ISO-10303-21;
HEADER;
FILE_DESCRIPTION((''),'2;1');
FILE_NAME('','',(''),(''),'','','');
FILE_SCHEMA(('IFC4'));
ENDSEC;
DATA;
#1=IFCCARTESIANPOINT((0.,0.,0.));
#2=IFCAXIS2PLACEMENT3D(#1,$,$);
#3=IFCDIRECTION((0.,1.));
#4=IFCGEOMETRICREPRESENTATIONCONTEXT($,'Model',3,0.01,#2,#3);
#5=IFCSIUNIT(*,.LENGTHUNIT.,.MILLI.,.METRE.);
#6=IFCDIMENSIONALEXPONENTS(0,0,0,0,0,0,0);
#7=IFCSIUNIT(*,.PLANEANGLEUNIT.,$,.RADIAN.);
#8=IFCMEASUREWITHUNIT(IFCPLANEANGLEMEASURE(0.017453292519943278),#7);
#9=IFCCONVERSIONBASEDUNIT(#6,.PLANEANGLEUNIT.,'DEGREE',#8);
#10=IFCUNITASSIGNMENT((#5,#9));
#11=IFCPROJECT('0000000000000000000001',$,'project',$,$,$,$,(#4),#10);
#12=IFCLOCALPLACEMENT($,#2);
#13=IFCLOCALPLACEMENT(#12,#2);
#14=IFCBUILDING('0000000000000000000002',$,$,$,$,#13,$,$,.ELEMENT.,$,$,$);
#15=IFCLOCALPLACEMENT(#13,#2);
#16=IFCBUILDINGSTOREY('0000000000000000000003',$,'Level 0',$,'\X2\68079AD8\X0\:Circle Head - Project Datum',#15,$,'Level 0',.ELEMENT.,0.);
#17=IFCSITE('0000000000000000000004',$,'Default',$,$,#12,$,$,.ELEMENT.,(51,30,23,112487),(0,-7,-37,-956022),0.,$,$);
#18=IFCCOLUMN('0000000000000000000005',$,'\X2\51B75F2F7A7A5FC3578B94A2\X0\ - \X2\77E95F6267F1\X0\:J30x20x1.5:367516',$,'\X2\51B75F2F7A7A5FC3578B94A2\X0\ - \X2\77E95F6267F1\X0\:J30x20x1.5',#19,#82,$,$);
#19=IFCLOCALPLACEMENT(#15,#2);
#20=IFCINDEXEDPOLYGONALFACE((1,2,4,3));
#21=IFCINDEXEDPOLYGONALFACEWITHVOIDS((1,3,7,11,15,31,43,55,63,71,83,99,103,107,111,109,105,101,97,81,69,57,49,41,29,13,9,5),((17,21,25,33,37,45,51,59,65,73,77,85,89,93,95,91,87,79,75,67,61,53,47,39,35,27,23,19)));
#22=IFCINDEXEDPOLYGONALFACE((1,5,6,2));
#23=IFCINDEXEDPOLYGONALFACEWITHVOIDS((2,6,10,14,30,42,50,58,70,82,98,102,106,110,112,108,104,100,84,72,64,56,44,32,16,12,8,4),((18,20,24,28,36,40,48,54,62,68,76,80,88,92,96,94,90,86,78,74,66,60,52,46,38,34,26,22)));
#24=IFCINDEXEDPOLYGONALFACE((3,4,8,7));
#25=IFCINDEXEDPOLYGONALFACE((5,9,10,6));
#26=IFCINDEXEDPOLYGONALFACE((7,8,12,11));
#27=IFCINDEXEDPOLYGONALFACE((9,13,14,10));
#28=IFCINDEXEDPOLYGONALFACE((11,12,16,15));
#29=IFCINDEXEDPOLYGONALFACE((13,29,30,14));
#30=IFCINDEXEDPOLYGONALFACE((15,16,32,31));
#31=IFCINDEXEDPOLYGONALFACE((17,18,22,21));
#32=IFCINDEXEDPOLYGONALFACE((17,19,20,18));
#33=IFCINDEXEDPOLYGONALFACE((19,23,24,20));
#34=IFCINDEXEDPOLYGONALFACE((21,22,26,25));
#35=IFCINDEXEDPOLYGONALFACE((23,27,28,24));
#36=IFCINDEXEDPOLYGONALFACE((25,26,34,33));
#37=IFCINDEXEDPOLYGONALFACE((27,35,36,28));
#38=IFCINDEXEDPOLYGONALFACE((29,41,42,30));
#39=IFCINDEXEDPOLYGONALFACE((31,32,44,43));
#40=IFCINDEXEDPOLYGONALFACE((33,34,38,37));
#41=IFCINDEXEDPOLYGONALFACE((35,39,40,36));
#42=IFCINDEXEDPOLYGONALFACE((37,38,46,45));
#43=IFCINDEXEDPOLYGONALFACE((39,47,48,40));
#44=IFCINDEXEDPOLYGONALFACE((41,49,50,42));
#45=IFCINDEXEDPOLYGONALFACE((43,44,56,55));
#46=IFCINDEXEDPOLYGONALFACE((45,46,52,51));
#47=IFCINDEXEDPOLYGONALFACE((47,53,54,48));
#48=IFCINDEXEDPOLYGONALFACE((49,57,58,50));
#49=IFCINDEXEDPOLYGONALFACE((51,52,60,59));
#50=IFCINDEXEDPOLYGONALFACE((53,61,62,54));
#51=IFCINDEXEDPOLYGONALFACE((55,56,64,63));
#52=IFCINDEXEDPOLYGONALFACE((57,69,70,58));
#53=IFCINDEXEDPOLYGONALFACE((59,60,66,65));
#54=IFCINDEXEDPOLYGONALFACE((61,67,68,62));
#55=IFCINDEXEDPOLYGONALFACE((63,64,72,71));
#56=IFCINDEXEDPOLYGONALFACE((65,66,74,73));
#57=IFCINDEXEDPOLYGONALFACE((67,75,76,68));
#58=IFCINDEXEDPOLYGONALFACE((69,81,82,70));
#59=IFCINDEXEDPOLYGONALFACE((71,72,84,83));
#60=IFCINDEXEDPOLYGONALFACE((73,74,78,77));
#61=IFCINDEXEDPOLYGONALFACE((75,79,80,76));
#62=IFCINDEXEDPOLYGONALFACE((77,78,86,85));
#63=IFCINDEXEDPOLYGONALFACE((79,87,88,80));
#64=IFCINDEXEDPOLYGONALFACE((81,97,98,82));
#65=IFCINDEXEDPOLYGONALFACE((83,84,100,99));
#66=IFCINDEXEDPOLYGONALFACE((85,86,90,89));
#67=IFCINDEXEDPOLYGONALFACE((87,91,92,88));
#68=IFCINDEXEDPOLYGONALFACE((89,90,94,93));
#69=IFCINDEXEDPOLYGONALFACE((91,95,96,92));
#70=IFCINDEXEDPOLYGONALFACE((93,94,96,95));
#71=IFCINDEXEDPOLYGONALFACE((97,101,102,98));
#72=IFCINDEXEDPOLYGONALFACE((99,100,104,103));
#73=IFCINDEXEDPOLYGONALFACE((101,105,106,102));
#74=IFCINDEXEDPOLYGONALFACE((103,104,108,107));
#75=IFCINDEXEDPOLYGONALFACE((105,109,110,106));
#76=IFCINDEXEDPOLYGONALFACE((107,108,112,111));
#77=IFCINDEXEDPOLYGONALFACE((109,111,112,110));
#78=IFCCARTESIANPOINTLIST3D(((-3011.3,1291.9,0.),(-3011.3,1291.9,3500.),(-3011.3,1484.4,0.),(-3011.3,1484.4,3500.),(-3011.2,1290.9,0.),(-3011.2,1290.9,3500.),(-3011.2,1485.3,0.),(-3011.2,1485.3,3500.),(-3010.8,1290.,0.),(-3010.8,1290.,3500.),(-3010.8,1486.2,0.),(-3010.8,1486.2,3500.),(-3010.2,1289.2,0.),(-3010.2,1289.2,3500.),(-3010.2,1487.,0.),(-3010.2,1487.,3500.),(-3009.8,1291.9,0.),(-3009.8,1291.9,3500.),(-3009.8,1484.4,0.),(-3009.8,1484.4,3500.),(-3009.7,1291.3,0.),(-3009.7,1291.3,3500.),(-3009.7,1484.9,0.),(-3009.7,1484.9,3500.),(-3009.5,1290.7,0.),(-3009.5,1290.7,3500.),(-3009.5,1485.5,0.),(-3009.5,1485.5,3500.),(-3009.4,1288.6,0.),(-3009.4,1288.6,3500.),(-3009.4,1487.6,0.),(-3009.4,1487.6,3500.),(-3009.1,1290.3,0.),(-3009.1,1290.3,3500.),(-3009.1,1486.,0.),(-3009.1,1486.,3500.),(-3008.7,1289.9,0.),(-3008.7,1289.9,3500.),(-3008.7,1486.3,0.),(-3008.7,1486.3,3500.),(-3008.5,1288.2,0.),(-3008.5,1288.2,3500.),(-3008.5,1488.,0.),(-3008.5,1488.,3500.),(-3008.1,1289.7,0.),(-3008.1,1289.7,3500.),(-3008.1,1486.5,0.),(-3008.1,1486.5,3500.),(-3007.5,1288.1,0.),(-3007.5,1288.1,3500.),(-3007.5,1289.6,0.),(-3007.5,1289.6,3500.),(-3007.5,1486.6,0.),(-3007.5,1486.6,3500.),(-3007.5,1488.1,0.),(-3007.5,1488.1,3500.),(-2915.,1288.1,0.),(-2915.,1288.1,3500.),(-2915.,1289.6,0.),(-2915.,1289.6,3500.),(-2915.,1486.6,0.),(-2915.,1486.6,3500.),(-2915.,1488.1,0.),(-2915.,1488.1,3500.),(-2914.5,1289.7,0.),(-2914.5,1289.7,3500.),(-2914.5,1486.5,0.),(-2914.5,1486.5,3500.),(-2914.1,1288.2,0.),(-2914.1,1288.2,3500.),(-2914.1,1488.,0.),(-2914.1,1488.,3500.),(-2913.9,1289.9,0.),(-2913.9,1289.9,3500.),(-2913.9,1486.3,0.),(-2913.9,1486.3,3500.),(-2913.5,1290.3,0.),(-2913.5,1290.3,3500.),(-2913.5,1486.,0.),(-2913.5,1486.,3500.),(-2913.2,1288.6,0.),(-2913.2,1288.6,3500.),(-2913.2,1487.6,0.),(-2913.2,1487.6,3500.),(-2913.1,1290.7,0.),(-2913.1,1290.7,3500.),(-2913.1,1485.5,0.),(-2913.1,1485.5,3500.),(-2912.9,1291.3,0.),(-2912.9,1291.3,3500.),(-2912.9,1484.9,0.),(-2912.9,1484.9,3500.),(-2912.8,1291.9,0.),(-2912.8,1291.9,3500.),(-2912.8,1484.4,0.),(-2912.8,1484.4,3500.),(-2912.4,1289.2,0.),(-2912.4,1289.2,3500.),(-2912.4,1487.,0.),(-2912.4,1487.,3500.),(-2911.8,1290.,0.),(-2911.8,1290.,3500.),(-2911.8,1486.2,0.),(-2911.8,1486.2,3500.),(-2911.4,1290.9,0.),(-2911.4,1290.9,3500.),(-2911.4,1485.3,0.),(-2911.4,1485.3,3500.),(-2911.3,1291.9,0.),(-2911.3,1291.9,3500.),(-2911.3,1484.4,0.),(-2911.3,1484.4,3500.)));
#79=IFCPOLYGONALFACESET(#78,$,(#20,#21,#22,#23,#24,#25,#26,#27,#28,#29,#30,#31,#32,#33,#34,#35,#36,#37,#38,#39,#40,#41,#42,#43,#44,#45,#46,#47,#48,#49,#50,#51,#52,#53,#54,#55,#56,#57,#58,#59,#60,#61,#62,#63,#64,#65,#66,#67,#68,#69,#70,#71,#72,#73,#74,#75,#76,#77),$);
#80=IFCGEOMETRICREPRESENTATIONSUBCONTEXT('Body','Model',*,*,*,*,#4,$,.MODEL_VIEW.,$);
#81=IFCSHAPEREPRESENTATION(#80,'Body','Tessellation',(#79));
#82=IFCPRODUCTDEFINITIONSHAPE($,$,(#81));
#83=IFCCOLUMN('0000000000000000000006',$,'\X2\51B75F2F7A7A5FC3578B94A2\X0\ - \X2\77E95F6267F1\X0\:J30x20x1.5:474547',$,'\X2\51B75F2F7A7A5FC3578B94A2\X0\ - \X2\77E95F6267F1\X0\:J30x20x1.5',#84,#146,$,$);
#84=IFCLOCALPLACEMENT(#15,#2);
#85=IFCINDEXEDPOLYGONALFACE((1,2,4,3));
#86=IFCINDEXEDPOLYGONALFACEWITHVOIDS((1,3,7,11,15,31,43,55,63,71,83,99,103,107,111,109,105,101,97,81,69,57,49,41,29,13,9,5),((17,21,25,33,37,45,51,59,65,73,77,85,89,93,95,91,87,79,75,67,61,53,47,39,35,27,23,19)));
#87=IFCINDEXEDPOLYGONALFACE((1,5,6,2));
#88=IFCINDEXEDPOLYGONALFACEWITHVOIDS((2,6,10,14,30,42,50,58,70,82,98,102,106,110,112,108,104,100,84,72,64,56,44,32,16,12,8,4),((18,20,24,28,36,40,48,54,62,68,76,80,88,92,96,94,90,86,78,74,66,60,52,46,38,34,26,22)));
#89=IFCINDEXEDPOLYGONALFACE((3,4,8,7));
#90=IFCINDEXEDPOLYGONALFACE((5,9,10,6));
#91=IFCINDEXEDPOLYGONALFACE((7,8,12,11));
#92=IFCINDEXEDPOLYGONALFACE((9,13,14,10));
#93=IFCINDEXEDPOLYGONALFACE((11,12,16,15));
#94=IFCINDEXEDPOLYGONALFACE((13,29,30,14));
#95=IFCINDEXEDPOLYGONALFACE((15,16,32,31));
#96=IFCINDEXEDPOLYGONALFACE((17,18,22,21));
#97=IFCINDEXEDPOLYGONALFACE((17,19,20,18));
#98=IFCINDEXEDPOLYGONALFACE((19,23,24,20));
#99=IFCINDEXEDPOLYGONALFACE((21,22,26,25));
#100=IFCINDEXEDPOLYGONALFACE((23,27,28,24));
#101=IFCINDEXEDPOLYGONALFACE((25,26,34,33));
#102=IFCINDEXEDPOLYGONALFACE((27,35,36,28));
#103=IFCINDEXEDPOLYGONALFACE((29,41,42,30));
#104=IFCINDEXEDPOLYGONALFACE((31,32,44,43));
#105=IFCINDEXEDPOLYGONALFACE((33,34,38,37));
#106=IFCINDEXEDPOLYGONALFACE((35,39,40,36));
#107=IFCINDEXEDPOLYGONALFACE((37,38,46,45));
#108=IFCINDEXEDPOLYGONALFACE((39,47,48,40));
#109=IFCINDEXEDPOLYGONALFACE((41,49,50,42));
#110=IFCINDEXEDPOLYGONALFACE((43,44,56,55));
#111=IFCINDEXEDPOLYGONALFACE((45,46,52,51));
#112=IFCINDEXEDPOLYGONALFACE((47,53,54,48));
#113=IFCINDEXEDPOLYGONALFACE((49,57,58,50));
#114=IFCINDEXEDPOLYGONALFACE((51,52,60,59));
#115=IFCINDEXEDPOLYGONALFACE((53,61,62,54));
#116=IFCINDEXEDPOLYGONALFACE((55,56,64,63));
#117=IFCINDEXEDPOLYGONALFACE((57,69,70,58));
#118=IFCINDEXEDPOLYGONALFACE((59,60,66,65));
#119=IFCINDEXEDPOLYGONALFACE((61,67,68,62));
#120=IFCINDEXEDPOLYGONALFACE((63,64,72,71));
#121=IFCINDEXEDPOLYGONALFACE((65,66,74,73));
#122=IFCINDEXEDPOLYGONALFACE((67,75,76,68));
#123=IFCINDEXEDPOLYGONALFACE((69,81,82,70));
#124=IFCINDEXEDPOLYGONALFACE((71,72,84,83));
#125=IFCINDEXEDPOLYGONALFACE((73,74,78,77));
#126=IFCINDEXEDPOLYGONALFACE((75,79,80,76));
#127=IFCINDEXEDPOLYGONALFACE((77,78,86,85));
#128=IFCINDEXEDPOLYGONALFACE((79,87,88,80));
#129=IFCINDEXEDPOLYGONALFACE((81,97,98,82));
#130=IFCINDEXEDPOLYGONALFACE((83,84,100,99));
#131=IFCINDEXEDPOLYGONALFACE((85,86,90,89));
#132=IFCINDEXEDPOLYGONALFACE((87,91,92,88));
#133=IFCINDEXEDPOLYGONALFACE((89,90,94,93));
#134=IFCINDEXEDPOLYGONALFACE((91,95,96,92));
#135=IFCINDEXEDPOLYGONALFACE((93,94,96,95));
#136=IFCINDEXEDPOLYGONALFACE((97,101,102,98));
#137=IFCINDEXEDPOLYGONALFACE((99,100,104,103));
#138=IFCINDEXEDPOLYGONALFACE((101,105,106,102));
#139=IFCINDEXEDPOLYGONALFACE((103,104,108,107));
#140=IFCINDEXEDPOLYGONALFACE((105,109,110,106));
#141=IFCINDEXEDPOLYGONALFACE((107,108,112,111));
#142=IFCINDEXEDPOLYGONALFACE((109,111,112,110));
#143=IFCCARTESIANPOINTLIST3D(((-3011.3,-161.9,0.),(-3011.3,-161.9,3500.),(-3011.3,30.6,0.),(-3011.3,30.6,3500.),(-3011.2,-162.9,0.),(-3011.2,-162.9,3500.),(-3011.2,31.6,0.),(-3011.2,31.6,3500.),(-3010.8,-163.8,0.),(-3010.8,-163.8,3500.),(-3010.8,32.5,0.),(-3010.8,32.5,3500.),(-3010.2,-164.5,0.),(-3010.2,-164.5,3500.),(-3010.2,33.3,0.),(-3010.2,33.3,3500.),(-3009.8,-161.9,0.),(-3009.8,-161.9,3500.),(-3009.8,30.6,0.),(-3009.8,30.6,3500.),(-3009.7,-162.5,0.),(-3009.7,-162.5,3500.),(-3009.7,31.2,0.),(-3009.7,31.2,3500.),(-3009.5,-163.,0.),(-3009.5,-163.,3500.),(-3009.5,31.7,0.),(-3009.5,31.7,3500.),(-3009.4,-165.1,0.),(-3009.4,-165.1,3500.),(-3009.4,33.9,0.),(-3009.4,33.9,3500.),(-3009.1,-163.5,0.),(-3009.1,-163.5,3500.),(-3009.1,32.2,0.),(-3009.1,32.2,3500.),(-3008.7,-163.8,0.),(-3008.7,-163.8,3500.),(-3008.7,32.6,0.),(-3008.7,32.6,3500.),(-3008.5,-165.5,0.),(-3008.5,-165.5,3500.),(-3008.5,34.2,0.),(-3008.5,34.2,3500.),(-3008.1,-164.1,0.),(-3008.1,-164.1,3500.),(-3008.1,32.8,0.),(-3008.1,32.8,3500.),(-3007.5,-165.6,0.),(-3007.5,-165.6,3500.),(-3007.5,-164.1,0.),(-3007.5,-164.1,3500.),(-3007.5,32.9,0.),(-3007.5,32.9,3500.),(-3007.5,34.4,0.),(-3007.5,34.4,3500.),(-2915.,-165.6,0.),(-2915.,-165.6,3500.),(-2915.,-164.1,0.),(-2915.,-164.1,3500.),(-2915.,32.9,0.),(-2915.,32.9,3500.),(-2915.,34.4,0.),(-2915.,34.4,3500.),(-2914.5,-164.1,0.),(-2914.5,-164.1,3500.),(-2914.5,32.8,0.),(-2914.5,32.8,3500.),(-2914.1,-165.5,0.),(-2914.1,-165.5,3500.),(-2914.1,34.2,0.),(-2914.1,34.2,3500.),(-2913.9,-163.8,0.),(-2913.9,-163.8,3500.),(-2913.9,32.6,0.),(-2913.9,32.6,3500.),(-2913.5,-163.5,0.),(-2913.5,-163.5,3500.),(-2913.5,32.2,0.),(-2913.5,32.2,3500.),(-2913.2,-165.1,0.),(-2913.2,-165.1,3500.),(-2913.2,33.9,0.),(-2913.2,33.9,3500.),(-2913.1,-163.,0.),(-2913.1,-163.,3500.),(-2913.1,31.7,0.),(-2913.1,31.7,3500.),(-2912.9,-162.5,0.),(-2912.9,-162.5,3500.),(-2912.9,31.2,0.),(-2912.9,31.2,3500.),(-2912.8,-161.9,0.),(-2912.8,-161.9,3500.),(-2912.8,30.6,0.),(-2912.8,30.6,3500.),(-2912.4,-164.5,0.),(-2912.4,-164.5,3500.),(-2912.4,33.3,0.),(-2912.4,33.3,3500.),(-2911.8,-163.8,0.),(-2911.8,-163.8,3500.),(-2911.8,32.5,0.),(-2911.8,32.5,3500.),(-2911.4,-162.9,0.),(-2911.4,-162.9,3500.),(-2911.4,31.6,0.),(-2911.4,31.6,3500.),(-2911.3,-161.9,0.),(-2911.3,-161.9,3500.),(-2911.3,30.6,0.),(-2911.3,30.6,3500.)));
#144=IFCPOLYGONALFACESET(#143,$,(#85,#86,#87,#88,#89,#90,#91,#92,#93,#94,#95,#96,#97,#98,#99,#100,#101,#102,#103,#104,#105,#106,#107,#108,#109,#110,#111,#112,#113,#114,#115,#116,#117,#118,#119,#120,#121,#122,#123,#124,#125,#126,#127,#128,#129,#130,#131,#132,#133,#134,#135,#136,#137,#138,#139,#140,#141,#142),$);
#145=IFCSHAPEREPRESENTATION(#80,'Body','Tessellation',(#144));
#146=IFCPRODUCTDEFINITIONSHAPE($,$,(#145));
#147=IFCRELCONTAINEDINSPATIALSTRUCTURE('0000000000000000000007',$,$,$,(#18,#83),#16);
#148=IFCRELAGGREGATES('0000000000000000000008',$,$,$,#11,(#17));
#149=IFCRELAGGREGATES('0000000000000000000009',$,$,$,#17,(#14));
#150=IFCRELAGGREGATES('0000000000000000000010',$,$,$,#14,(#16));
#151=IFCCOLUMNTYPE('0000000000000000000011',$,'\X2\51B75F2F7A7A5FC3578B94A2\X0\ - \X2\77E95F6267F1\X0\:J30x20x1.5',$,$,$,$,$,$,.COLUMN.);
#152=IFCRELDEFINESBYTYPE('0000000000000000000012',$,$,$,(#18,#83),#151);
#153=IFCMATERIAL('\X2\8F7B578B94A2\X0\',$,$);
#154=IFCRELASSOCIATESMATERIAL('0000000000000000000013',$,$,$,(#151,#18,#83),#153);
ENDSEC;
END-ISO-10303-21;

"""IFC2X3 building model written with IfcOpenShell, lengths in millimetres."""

from ifc_helpers import new_model, entity, si_unit, converted_unit, direction, frame, frame_2d, origin, place, context, subcontext, project, spatial, polyline, circle_curve, parameter, trimmed, segment, composite_curve, outline, extrude, source, transform, mapped, material, type_object, type_shapes, element, save


model = new_model("IFC2X3")

# Units and contexts
model_context = context("Model", 3, precision=0.01, world=origin(), true_north=direction((0.0, 1.0)))
body_context = subcontext(model_context, "Body", "Model", "MODEL_VIEW")
ifc_project = project(units=[si_unit("LENGTHUNIT", "METRE", prefix="MILLI"), converted_unit("PLANEANGLEUNIT", "DEGREE", entity("IfcPlaneAngleMeasure", 0.017453292519943278), si_unit("PLANEANGLEUNIT", "RADIAN"), dimensions=[0, 0, 0, 0, 0, 0, 0])], contexts=[model_context])

# Site, building, storey
site_placement = place(None, origin())
site = spatial("IfcSite", under=ifc_project, at=site_placement, Name="Default", CompositionType="ELEMENT", RefLatitude=(51, 30, 23, 112487), RefLongitude=(0, -7, -37, -956022), RefElevation=0.0)
building_placement = place(site_placement, origin())
building = spatial("IfcBuilding", under=site, at=building_placement, CompositionType="ELEMENT")
storey_placement = place(building_placement, origin())
storey = spatial("IfcBuildingStorey", under=building, at=storey_placement, Name="Level 0", ObjectType="标高:Circle Head - Project Datum", LongName="Level 0", CompositionType="ELEMENT", Elevation=0.0)

# Columns
ifc_material_1 = material(Name="轻型钢")
column_type = type_object("IfcColumnType", Name="冷弯空心型钢 - 矩形柱:J30x20x1.5", PredefinedType="COLUMN", material=ifc_material_1)
shared_shape_1 = source(origin(), body_context, "Body", "SweptSolid", [
    extrude(outline(composite_curve([segment(polyline([(-46.2, -100.0), (46.3, -100.0)]), True, "CONTINUOUS"), segment(trimmed(circle_curve(frame_2d((46.3, -96.3), x_axis=(-1.0, 0.0)), 3.8), [parameter(90.0)], [parameter(180.0)], True, "PARAMETER"), True, "CONTINUOUS"), segment(polyline([(50.0, -96.3), (50.0, 96.3)]), True, "CONTINUOUS"), segment(trimmed(circle_curve(frame_2d((46.2, 96.3), x_axis=(-1.0, 0.0)), 3.8), [parameter(180.0)], [parameter(270.0)], True, "PARAMETER"), True, "CONTINUOUS"), segment(polyline([(46.2, 100.0), (-46.2, 100.0)]), True, "CONTINUOUS"), segment(trimmed(circle_curve(frame_2d((-46.2, 96.3), x_axis=(-1.0, 0.0)), 3.8), [parameter(270.0)], [parameter(0.0)], True, "PARAMETER"), True, "CONTINUOUS"), segment(polyline([(-50.0, 96.3), (-50.0, -96.3)]), True, "CONTINUOUS"), segment(trimmed(circle_curve(frame_2d((-46.2, -96.3), x_axis=(-1.0, 0.0)), 3.8), [parameter(360.0)], [parameter(90.0)], True, "PARAMETER"), True, "CONTINUOUS")], self_intersect=False), holes=[composite_curve([segment(trimmed(circle_curve(frame_2d((-46.3, -96.3), x_axis=(-1.0, 0.0)), 2.2), [parameter(0.0)], [parameter(90.0)], True, "PARAMETER"), False, "CONTINUOUS"), segment(polyline([(-48.5, -96.3), (-48.5, 96.3)]), True, "CONTINUOUS"), segment(trimmed(circle_curve(frame_2d((-46.3, 96.3), x_axis=(-1.0, 0.0)), 2.2), [parameter(270.0)], [parameter(0.0)], True, "PARAMETER"), False, "CONTINUOUS"), segment(polyline([(-46.3, 98.5), (46.2, 98.5)]), True, "CONTINUOUS"), segment(trimmed(circle_curve(frame_2d((46.2, 96.3), x_axis=(-1.0, 0.0)), 2.2), [parameter(180.0)], [parameter(270.0)], True, "PARAMETER"), False, "CONTINUOUS"), segment(polyline([(48.5, 96.3), (48.5, -96.3)]), True, "CONTINUOUS"), segment(trimmed(circle_curve(frame_2d((46.3, -96.3), x_axis=(-1.0, 0.0)), 2.2), [parameter(90.0)], [parameter(180.0)], True, "PARAMETER"), False, "CONTINUOUS"), segment(polyline([(46.3, -98.5), (-46.3, -98.5)]), True, "CONTINUOUS")], self_intersect=False)]), frame((0.0, 0.0, 0.0), z_axis=(0.0, 0.0, 1.0), x_axis=(-1.0, 0.0, 0.0)), (0.0, 0.0, 1.0), 3500.0),
])
type_shapes(column_type, [shared_shape_1])
for number, where, name in (
    (1, (-2961.3, 1388.1, 0.0), "冷弯空心型钢 - 矩形柱:J30x20x1.5:367516"),
    (2, (-2961.3, -65.6, 0.0), "冷弯空心型钢 - 矩形柱:J30x20x1.5:474547"),
):
    element("IfcColumn", number, at=place(storey_placement, frame(where)), inside=storey, type_object=column_type, material=ifc_material_1, Name=name, ObjectType="冷弯空心型钢 - 矩形柱:J30x20x1.5", context=body_context, shape_type="MappedRepresentation", body=[
        mapped(shared_shape_1, transform((0.0, 0.0, 0.0), scale=1.0)),
    ])

save(model, "model.ifc")
